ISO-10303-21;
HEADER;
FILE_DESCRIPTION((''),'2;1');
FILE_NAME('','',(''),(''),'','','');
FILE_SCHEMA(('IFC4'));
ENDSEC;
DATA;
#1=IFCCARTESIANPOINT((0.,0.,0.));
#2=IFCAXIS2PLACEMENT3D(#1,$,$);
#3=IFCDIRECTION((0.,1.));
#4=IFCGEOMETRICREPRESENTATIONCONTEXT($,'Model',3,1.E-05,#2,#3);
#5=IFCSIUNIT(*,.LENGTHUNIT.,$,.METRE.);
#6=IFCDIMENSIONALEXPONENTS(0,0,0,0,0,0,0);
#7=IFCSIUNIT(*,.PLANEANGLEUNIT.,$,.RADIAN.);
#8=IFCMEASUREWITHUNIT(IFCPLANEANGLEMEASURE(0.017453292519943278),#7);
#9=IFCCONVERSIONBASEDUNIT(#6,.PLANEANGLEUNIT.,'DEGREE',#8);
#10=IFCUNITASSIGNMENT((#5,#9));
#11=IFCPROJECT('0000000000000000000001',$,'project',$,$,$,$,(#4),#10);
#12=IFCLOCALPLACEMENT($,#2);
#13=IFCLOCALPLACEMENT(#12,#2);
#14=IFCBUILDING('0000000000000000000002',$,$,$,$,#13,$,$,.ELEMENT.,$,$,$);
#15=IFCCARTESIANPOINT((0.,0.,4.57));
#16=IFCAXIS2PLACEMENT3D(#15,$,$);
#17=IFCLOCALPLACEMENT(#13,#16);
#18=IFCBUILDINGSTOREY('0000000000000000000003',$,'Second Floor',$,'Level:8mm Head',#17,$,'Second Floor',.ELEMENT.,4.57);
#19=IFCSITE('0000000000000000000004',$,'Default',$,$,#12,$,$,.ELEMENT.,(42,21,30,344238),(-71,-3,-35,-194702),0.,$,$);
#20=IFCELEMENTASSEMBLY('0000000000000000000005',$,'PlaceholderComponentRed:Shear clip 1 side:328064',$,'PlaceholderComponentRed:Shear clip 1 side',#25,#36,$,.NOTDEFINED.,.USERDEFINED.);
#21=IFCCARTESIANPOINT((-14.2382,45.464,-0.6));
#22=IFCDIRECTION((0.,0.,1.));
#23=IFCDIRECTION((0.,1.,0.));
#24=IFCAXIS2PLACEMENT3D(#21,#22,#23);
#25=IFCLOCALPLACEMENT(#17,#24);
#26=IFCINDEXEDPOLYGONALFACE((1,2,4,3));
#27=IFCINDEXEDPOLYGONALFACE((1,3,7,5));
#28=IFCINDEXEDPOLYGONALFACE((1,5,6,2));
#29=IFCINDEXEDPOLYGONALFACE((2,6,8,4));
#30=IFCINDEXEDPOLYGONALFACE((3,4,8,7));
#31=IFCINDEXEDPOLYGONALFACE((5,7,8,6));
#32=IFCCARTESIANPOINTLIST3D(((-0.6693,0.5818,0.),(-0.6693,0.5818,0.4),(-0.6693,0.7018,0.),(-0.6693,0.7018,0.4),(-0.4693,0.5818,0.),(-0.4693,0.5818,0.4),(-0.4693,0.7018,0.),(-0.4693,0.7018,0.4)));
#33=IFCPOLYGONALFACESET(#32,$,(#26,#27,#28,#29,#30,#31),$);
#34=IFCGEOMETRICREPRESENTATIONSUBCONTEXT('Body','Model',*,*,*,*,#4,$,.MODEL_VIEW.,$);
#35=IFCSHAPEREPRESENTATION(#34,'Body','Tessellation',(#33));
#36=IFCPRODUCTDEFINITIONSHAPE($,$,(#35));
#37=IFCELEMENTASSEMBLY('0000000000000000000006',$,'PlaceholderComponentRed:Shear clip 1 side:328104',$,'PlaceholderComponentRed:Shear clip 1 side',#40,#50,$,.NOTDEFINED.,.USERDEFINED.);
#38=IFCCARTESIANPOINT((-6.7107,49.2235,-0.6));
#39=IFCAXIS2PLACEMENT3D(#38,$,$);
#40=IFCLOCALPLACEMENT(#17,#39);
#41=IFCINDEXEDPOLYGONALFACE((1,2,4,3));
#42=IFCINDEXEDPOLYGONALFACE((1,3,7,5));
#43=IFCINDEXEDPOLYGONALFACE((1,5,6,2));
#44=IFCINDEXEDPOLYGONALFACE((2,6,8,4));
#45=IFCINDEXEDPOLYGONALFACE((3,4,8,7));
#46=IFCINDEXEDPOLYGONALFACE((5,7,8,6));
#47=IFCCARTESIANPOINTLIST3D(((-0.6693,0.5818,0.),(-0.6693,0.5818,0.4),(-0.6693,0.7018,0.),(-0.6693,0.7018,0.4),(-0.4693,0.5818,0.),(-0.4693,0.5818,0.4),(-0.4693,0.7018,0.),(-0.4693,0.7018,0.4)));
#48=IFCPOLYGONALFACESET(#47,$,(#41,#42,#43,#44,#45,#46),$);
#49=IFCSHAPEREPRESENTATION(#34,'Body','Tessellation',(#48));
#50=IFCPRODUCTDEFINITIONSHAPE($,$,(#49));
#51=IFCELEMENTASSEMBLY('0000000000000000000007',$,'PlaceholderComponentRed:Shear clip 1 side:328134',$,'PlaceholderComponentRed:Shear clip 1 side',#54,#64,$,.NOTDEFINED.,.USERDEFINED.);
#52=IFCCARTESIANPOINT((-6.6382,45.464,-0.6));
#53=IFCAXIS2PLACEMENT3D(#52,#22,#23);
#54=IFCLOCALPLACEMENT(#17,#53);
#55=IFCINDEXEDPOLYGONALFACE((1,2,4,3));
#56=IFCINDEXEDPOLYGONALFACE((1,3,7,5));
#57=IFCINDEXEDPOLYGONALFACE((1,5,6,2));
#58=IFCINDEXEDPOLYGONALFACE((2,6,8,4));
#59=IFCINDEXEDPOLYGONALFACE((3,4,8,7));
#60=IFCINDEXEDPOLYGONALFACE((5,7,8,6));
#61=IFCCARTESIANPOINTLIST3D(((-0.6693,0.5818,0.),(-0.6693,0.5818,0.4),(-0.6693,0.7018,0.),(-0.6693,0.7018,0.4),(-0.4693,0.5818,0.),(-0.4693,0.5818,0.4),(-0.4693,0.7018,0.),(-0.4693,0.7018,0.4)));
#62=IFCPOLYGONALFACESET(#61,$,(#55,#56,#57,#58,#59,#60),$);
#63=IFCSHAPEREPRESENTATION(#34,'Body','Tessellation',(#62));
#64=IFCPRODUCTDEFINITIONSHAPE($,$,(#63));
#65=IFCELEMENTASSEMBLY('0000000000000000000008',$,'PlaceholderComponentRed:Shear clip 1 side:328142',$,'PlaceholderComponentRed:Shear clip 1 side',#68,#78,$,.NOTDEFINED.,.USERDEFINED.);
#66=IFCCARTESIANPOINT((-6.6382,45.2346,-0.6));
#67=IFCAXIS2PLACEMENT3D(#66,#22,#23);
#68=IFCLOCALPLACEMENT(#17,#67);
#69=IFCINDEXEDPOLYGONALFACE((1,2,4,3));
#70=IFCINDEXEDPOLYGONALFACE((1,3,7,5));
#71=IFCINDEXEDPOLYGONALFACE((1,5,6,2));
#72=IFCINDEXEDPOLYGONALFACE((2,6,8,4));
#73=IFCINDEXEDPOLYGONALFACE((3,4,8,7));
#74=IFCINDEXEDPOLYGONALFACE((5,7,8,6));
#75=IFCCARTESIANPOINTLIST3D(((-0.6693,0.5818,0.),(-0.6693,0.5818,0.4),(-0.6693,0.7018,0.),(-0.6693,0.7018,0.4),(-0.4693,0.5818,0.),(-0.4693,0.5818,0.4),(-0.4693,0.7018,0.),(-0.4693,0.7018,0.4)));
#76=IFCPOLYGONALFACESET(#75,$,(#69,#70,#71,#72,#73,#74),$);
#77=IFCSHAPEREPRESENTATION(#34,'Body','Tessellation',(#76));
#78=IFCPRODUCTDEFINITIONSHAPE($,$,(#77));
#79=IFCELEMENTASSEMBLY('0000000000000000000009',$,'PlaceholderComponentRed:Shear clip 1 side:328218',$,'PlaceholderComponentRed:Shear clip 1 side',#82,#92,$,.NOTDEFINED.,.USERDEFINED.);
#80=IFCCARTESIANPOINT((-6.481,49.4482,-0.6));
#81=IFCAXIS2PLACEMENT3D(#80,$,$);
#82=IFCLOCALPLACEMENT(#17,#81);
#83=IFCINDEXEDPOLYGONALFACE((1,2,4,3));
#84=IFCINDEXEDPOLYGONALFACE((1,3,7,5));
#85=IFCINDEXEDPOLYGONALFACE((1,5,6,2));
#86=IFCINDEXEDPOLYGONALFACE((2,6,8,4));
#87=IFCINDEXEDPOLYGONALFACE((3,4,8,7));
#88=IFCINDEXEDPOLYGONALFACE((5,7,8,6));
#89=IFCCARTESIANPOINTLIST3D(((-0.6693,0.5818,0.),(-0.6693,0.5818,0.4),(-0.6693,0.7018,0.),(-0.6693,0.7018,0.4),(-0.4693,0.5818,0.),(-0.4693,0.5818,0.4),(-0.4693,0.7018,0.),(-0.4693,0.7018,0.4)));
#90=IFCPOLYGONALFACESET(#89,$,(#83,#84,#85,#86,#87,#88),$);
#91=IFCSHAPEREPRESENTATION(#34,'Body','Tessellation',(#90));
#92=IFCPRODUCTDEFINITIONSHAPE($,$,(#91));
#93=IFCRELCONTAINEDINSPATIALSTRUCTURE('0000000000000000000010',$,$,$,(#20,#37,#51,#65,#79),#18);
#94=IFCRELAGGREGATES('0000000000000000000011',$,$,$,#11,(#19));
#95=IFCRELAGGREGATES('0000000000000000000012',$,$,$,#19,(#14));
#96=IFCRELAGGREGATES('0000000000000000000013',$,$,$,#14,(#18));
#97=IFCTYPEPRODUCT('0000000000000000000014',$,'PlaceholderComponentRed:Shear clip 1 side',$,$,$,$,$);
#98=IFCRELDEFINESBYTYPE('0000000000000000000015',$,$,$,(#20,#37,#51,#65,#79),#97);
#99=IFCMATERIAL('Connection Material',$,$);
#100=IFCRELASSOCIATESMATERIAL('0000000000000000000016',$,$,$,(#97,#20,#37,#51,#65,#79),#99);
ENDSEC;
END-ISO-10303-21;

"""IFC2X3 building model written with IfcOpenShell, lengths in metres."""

from ifc_helpers import new_model, entity, si_unit, converted_unit, direction, frame, frame_2d, origin, place, context, subcontext, project, spatial, rectangle, extrude, source, transform, mapped, material, type_object, type_shapes, element, save


model = new_model("IFC2X3")

# Units and contexts
model_context = context("Model", 3, precision=1e-05, world=origin(), true_north=direction((0.0, 1.0)))
body_context = subcontext(model_context, "Body", "Model", "MODEL_VIEW")
ifc_project = project(units=[si_unit("LENGTHUNIT", "METRE"), converted_unit("PLANEANGLEUNIT", "DEGREE", entity("IfcPlaneAngleMeasure", 0.017453292519943278), si_unit("PLANEANGLEUNIT", "RADIAN"), dimensions=[0, 0, 0, 0, 0, 0, 0])], contexts=[model_context])

# Site, building, storey
site_placement = place(None, origin())
site = spatial("IfcSite", under=ifc_project, at=site_placement, Name="Default", CompositionType="ELEMENT", RefLatitude=(42, 21, 30, 344238), RefLongitude=(-71, -3, -35, -194702), RefElevation=0.0)
building_placement = place(site_placement, origin())
building = spatial("IfcBuilding", under=site, at=building_placement, CompositionType="ELEMENT")
storey_placement = place(building_placement, frame((0.0, 0.0, 4.57)))
storey = spatial("IfcBuildingStorey", under=building, at=storey_placement, Name="Second Floor", ObjectType="Level:8mm Head", LongName="Second Floor", CompositionType="ELEMENT", Elevation=4.57)

# Element assemblies
ifc_material_1 = material(Name="Connection Material")
type_product = type_object("IfcTypeProduct", Name="PlaceholderComponentRed:Shear clip 1 side", material=ifc_material_1)
shared_shape = source(origin(), body_context, "Body", "SweptSolid", [
    extrude(rectangle(XDim=0.12, YDim=0.2, at=frame_2d((0.0, 0.0), x_axis=(1.0, 0.0))), frame((-0.5693, 0.6418, 0.0), z_axis=(0.0, 0.0, 1.0), x_axis=(0.0, 1.0, 0.0)), (0.0, 0.0, 1.0), 0.4),
])
type_shapes(type_product, [shared_shape])
assembly_1_placement = place(storey_placement, frame((-14.2382, 45.464, -0.6), z_axis=(0.0, 0.0, 1.0), x_axis=(0.0, 1.0, 0.0)))
element("IfcElementAssembly", 1, at=assembly_1_placement, inside=storey, type_object=type_product, material=ifc_material_1, Name="PlaceholderComponentRed:Shear clip 1 side:328064", ObjectType="PlaceholderComponentRed:Shear clip 1 side", AssemblyPlace="NOTDEFINED", PredefinedType="USERDEFINED", context=body_context, shape_type="MappedRepresentation", body=[
    mapped(shared_shape, transform((0.0, 0.0, 0.0), scale=1.0)),
])
assembly_2_placement = place(storey_placement, frame((-6.7107, 49.2235, -0.6)))
element("IfcElementAssembly", 2, at=assembly_2_placement, inside=storey, type_object=type_product, material=ifc_material_1, Name="PlaceholderComponentRed:Shear clip 1 side:328104", ObjectType="PlaceholderComponentRed:Shear clip 1 side", AssemblyPlace="NOTDEFINED", PredefinedType="USERDEFINED", context=body_context, shape_type="MappedRepresentation", body=[
    mapped(shared_shape, transform((0.0, 0.0, 0.0), scale=1.0)),
])
for number, where, z_axis, x_axis, name in (
    (3, (-6.6382, 45.464, -0.6), (0.0, 0.0, 1.0), (0.0, 1.0, 0.0), "PlaceholderComponentRed:Shear clip 1 side:328134"),
    (4, (-6.6382, 45.2346, -0.6), (0.0, 0.0, 1.0), (0.0, 1.0, 0.0), "PlaceholderComponentRed:Shear clip 1 side:328142"),
):
    element("IfcElementAssembly", number, at=place(storey_placement, frame(where, z_axis=z_axis, x_axis=x_axis)), inside=storey, type_object=type_product, material=ifc_material_1, Name=name, ObjectType="PlaceholderComponentRed:Shear clip 1 side", AssemblyPlace="NOTDEFINED", PredefinedType="USERDEFINED", context=body_context, shape_type="MappedRepresentation", body=[
        mapped(shared_shape, transform((0.0, 0.0, 0.0), scale=1.0)),
    ])
assembly_3_placement = place(storey_placement, frame((-6.481, 49.4482, -0.6)))
element("IfcElementAssembly", 5, at=assembly_3_placement, inside=storey, type_object=type_product, material=ifc_material_1, Name="PlaceholderComponentRed:Shear clip 1 side:328218", ObjectType="PlaceholderComponentRed:Shear clip 1 side", AssemblyPlace="NOTDEFINED", PredefinedType="USERDEFINED", context=body_context, shape_type="MappedRepresentation", body=[
    mapped(shared_shape, transform((0.0, 0.0, 0.0), scale=1.0)),
])

save(model, "model.ifc")
